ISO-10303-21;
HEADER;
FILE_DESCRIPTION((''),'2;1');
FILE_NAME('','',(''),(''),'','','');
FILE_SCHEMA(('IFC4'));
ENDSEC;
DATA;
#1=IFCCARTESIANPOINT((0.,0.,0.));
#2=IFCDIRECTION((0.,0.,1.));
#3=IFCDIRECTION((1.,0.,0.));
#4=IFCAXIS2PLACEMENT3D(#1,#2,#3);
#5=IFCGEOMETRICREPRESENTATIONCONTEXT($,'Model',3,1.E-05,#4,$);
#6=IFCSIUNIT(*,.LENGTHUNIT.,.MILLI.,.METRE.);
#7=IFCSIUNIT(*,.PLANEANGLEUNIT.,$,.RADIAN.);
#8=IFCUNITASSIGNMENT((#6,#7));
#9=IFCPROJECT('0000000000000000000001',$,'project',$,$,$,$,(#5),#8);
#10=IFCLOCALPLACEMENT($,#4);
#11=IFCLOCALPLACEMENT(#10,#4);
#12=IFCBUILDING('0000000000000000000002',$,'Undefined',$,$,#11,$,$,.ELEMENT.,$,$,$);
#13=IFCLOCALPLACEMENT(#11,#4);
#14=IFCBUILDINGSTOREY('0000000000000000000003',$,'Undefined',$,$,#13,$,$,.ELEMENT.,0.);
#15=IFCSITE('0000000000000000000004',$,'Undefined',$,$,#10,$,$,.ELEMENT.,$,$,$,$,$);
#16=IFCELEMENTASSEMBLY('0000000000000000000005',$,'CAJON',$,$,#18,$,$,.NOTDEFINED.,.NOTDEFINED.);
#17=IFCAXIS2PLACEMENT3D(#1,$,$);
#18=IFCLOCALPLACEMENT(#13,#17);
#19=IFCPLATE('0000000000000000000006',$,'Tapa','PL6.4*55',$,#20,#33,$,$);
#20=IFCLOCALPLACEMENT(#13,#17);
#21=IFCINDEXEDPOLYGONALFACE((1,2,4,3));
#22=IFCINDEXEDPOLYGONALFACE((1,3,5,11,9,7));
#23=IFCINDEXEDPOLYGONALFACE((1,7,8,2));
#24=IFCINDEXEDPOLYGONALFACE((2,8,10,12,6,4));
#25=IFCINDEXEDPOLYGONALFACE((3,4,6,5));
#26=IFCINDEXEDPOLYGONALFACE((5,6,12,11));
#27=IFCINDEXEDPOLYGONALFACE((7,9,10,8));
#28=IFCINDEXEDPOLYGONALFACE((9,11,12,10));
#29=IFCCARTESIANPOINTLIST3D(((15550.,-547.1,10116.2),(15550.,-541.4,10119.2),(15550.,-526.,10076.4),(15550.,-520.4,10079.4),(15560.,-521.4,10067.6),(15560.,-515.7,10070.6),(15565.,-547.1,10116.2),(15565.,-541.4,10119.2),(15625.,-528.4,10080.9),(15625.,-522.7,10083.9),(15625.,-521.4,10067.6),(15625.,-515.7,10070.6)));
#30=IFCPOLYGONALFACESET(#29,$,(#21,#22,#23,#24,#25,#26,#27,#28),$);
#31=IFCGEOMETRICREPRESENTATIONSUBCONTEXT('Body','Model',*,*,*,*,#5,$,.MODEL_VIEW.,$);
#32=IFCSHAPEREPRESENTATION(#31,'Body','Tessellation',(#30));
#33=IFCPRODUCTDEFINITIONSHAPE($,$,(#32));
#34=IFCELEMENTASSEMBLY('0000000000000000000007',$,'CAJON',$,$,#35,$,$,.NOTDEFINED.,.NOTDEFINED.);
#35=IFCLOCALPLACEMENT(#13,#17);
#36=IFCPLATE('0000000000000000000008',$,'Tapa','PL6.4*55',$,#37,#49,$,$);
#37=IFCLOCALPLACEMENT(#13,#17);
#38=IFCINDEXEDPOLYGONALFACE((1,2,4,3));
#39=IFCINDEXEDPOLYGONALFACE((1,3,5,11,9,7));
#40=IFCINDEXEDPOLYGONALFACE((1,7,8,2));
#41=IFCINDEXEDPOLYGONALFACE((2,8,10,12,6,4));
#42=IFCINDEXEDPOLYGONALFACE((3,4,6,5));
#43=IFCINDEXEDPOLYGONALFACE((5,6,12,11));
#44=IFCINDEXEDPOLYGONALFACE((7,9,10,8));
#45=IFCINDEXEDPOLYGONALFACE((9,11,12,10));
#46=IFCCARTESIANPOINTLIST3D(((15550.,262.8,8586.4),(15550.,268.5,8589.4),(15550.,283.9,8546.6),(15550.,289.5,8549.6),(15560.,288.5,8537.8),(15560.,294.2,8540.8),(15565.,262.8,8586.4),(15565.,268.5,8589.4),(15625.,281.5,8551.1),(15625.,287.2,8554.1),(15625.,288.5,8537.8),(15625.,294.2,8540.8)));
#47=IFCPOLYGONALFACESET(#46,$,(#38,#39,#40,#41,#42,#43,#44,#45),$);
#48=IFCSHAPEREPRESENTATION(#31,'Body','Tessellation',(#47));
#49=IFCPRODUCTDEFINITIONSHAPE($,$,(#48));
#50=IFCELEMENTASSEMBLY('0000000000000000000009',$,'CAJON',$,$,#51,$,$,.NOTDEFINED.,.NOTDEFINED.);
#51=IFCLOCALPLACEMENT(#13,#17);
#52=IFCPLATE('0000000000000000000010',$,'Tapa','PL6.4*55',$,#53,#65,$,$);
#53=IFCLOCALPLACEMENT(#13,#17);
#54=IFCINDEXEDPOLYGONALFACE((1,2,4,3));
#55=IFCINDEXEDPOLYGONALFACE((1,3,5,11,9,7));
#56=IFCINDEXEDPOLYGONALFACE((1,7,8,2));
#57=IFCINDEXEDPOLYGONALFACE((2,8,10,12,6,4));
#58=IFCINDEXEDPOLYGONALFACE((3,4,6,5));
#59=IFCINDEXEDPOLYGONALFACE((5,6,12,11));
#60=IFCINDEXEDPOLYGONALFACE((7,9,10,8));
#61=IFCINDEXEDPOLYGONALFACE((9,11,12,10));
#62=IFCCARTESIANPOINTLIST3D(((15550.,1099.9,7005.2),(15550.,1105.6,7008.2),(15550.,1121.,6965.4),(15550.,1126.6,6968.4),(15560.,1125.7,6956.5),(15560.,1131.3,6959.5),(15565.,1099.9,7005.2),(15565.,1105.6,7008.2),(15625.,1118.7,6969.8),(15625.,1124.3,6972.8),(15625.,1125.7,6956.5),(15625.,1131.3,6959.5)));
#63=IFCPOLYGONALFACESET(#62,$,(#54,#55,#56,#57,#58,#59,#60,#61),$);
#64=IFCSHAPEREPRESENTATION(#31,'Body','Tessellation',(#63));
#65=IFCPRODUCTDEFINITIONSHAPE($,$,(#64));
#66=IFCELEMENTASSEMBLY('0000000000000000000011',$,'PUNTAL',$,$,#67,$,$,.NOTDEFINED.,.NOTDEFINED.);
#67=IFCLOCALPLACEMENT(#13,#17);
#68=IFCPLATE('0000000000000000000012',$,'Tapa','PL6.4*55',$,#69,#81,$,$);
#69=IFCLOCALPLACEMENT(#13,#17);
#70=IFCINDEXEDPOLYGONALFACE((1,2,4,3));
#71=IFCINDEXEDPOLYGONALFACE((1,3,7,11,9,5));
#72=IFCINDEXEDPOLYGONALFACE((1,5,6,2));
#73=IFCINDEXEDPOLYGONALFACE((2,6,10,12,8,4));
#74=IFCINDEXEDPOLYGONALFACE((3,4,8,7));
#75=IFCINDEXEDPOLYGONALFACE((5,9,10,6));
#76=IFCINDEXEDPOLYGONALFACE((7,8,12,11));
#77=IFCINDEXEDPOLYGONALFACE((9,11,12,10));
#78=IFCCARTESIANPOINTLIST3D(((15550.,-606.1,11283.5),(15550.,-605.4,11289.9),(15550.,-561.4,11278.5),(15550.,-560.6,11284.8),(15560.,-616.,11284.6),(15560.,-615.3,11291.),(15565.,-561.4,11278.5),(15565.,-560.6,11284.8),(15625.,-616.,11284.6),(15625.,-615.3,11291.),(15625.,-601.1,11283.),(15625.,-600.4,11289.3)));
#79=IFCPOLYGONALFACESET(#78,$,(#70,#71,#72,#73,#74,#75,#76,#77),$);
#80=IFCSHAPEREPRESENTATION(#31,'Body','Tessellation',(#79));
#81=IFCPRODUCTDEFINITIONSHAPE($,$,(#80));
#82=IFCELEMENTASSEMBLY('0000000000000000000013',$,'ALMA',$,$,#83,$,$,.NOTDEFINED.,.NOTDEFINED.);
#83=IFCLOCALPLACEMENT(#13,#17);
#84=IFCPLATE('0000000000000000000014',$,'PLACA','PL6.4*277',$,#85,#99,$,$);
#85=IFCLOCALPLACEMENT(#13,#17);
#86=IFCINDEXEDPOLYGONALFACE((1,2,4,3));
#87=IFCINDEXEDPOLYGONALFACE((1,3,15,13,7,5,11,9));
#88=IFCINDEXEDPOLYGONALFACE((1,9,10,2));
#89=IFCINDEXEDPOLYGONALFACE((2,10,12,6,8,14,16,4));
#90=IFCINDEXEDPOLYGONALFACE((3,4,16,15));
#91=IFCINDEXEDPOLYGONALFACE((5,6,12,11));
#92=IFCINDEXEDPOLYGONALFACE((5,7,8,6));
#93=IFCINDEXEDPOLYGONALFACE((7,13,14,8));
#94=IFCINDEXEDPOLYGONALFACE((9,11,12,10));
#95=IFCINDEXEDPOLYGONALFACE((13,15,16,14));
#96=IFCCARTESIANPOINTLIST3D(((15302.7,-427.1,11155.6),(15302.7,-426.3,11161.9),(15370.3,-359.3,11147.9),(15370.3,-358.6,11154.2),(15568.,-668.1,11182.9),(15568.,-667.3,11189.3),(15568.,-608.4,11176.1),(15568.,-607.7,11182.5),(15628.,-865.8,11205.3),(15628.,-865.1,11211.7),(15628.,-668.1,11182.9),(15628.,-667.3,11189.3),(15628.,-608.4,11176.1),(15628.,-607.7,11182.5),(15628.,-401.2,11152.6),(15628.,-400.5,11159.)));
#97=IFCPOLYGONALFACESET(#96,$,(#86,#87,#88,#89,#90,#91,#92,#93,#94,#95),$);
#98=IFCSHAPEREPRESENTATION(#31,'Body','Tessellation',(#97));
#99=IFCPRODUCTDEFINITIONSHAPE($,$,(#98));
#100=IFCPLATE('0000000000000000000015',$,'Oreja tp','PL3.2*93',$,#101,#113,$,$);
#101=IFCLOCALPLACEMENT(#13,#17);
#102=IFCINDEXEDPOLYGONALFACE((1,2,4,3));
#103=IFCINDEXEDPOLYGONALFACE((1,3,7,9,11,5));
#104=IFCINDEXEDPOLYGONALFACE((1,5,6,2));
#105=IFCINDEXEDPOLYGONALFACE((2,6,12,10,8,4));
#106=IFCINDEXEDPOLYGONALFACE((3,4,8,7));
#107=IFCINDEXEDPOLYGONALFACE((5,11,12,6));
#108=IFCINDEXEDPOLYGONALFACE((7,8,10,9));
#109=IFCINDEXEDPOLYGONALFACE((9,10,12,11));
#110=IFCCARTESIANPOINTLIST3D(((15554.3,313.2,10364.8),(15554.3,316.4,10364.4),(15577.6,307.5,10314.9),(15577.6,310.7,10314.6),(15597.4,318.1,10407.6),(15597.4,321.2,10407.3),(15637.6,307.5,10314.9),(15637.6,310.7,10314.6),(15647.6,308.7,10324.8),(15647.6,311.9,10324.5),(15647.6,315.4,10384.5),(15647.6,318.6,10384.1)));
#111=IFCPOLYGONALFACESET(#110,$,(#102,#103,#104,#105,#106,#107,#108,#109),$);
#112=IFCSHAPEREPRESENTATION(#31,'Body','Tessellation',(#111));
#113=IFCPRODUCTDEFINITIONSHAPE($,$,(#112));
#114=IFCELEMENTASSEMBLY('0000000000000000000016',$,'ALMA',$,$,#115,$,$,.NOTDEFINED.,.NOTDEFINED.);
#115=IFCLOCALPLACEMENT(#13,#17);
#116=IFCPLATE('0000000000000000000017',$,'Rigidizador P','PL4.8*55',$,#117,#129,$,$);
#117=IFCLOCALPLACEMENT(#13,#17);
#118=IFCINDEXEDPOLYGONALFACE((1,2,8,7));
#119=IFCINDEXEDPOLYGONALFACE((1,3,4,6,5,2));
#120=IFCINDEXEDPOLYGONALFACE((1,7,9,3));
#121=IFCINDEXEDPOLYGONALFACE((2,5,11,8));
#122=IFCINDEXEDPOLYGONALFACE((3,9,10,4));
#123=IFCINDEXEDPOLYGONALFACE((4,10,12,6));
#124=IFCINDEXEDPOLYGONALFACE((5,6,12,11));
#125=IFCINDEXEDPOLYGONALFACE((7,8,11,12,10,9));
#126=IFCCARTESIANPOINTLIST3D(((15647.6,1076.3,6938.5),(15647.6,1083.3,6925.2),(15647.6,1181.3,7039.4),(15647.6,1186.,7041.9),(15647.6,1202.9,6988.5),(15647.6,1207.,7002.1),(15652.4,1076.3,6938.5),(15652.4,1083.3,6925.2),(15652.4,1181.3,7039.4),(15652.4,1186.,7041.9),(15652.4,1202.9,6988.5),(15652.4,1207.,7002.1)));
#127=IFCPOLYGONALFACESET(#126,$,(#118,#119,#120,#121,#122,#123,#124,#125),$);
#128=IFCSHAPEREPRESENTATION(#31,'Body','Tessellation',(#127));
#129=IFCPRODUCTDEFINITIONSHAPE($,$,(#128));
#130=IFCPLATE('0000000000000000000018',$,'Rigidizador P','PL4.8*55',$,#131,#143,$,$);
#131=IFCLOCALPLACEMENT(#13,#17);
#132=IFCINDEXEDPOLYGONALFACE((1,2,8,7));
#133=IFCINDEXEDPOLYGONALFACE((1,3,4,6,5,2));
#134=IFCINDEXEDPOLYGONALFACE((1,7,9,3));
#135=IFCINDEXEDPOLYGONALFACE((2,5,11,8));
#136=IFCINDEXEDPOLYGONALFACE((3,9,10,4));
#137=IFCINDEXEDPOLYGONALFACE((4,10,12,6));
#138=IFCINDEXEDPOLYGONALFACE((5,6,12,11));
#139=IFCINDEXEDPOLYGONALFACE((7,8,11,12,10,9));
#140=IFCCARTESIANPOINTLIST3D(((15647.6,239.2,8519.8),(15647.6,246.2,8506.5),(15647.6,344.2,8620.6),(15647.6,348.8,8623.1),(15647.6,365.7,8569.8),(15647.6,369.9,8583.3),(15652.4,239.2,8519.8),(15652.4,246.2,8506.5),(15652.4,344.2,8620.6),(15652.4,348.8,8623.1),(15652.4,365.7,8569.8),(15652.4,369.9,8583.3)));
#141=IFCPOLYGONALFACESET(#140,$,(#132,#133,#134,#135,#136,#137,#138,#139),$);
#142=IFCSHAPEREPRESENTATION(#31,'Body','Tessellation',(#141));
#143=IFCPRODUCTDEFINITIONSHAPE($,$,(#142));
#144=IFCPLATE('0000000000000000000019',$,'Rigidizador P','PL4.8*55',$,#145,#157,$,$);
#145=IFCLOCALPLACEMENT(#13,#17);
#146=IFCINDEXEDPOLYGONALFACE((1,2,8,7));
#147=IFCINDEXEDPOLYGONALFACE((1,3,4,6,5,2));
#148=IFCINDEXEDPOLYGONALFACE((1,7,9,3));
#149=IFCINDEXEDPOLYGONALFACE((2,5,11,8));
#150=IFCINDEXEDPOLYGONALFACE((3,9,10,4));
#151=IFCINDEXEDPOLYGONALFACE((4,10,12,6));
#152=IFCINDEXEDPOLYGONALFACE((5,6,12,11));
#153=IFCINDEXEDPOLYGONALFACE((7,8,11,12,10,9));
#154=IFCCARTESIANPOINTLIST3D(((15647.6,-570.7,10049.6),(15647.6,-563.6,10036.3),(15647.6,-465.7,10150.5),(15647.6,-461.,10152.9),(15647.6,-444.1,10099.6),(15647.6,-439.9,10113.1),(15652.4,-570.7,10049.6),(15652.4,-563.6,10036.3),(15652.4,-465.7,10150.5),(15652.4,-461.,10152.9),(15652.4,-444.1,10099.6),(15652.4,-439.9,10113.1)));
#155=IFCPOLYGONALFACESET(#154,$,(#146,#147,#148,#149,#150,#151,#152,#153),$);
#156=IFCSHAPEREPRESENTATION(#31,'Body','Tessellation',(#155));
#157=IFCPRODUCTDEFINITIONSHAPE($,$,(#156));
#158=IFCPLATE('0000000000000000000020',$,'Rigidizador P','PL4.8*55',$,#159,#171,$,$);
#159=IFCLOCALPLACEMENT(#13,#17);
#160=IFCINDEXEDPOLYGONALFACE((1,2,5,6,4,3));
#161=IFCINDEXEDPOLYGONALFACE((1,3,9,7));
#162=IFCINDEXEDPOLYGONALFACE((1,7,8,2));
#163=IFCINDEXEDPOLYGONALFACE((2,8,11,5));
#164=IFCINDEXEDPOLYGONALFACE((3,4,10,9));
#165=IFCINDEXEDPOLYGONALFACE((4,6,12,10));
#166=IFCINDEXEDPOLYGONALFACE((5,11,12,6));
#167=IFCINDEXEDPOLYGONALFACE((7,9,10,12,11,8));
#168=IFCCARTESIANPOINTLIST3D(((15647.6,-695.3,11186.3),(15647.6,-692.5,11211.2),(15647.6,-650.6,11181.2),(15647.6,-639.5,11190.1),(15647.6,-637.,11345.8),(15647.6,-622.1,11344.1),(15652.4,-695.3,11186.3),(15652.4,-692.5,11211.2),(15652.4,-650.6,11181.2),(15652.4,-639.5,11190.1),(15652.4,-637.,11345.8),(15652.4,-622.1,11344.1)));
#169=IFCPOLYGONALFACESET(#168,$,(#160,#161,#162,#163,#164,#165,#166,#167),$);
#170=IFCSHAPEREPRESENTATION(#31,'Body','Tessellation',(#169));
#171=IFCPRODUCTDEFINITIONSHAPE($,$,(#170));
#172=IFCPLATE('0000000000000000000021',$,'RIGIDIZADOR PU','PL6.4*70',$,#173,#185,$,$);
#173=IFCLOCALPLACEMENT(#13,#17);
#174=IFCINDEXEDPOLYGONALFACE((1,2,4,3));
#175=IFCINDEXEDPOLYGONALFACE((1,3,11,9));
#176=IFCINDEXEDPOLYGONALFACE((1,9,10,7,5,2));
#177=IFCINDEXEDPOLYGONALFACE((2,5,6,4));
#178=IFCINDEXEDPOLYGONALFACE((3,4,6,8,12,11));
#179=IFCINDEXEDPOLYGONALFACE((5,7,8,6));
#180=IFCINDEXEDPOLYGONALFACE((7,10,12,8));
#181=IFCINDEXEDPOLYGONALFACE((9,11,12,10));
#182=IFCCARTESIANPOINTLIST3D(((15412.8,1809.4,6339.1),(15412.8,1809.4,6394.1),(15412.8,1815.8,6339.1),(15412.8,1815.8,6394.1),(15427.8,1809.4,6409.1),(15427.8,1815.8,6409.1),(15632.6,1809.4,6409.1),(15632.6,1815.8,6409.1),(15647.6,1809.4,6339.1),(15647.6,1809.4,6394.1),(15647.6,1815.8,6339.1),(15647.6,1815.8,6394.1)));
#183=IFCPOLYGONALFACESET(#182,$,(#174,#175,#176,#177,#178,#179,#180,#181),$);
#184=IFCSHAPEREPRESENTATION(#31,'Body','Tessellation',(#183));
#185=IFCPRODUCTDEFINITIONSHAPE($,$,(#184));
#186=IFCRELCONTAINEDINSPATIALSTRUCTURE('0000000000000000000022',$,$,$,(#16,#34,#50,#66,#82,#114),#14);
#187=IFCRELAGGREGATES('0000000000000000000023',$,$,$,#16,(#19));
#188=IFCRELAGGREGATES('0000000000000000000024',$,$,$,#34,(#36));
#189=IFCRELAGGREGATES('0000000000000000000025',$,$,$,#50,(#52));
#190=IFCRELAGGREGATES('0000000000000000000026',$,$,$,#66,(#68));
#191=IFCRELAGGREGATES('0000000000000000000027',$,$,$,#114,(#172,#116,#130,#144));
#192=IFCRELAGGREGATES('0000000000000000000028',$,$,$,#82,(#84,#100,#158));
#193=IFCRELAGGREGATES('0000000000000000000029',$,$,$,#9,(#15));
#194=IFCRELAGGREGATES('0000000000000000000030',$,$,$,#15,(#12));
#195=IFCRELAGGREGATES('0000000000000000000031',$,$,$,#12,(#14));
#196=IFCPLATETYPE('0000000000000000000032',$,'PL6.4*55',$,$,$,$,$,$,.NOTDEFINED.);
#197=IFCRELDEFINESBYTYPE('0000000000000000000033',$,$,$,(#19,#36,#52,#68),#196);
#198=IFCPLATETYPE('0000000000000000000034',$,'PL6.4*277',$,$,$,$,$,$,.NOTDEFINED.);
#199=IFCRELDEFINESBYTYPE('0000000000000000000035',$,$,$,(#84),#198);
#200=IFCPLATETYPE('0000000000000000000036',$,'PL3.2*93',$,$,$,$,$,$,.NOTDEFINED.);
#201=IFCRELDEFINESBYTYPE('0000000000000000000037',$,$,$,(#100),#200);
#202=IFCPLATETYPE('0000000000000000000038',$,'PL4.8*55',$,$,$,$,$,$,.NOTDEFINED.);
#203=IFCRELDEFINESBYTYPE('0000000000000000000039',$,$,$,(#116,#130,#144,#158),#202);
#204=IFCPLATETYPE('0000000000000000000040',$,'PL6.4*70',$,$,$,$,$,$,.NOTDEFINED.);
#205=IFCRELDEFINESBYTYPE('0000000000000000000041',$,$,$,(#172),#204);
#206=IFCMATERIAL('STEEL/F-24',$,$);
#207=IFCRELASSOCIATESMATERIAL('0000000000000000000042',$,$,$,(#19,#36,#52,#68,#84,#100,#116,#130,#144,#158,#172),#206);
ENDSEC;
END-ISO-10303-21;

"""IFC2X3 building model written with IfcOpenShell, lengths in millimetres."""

from ifc_helpers import new_model, si_unit, frame, origin_with_axes, place, context, subcontext, project, spatial, polyline, outline, extrude, boolean, material, type_object, element, aggregate, save


model = new_model("IFC2X3")

# Units and contexts
model_context = context("Model", 3, precision=1e-05, world=origin_with_axes())
body_context = subcontext(model_context, "Body", "Model", "MODEL_VIEW")
ifc_project = project(units=[si_unit("LENGTHUNIT", "METRE", prefix="MILLI"), si_unit("PLANEANGLEUNIT", "RADIAN")], contexts=[model_context])

# Site, building, storey
site_placement = place(None, origin_with_axes())
site = spatial("IfcSite", under=ifc_project, at=site_placement, Name="Undefined", CompositionType="ELEMENT")
building_placement = place(site_placement, origin_with_axes())
building = spatial("IfcBuilding", under=site, at=building_placement, Name="Undefined", CompositionType="ELEMENT")
storey_placement = place(building_placement, origin_with_axes())
storey = spatial("IfcBuildingStorey", under=building, at=storey_placement, Name="Undefined", CompositionType="ELEMENT", Elevation=0.0)

# Element assemblies, plates
assembly_1_placement = place(storey_placement, origin_with_axes())
assembly_1 = element("IfcElementAssembly", 1, at=assembly_1_placement, inside=storey, Name="CAJON", AssemblyPlace="NOTDEFINED", PredefinedType="NOTDEFINED")
ifc_material_1 = material(Name="STEEL/F-24")
plate_type_1 = type_object("IfcPlateType", Name="PL6.4*55", PredefinedType="NOTDEFINED")
plate_1_placement = place(assembly_1_placement, frame((15625.0, -518.5, 10069.1), z_axis=(0.0, 0.883788, 0.467888), x_axis=(-1.0, 0.0, 0.0)))
plate_1 = element("IfcPlate", 2, at=plate_1_placement, type_object=plate_type_1, material=ifc_material_1, Name="Tapa", Description="PL6.4*55", context=body_context, shape_type="SweptSolid", body=[
    extrude(outline(polyline([(0.0, 0.0), (65.0, 0.0), (75.0, 10.0), (75.0, 55.0), (60.0, 55.0), (0.0, 15.0), (0.0, 0.0)])), frame((0.0, 0.0, -3.2), z_axis=(0.0, 0.0, 1.0), x_axis=(1.0, 0.0, 0.0)), (0.0, 0.0, 1.0), 6.4),
])
aggregate(assembly_1, [plate_1])
assembly_2_placement = place(storey_placement, origin_with_axes())
assembly_2 = element("IfcElementAssembly", 3, at=assembly_2_placement, inside=storey, Name="CAJON", AssemblyPlace="NOTDEFINED", PredefinedType="NOTDEFINED")
plate_2_placement = place(assembly_2_placement, frame((15625.0, 291.4, 8539.3), z_axis=(0.0, 0.883788, 0.467888), x_axis=(-1.0, 0.0, 0.0)))
plate_2 = element("IfcPlate", 4, at=plate_2_placement, type_object=plate_type_1, material=ifc_material_1, Name="Tapa", Description="PL6.4*55", context=body_context, shape_type="SweptSolid", body=[
    extrude(outline(polyline([(0.0, 0.0), (65.0, 0.0), (75.0, 10.0), (75.0, 55.0), (60.0, 55.0), (0.0, 15.0), (0.0, 0.0)])), frame((0.0, 0.0, -3.2), z_axis=(0.0, 0.0, 1.0), x_axis=(1.0, 0.0, 0.0)), (0.0, 0.0, 1.0), 6.4),
])
aggregate(assembly_2, [plate_2])
assembly_3_placement = place(storey_placement, origin_with_axes())
assembly_3 = element("IfcElementAssembly", 5, at=assembly_3_placement, inside=storey, Name="CAJON", AssemblyPlace="NOTDEFINED", PredefinedType="NOTDEFINED")
plate_3_placement = place(assembly_3_placement, frame((15625.0, 1128.5, 6958.0), z_axis=(0.0, 0.883788, 0.467888), x_axis=(-1.0, 0.0, 0.0)))
plate_3 = element("IfcPlate", 6, at=plate_3_placement, type_object=plate_type_1, material=ifc_material_1, Name="Tapa", Description="PL6.4*55", context=body_context, shape_type="SweptSolid", body=[
    extrude(outline(polyline([(0.0, 0.0), (65.0, 0.0), (75.0, 10.0), (75.0, 55.0), (60.0, 55.0), (0.0, 15.0), (0.0, 0.0)])), frame((0.0, 0.0, -3.2), z_axis=(0.0, 0.0, 1.0), x_axis=(1.0, 0.0, 0.0)), (0.0, 0.0, 1.0), 6.4),
])
aggregate(assembly_3, [plate_3])
assembly_4_placement = place(storey_placement, origin_with_axes())
assembly_4 = element("IfcElementAssembly", 7, at=assembly_4_placement, inside=storey, Name="PUNTAL", AssemblyPlace="NOTDEFINED", PredefinedType="NOTDEFINED")
plate_4_placement = place(assembly_4_placement, frame((15625.0, -615.7, 11287.8), z_axis=(0.0, -0.112644, -0.993635), x_axis=(-1.0, 0.0, 0.0)))
plate_4 = element("IfcPlate", 8, at=plate_4_placement, type_object=plate_type_1, material=ifc_material_1, Name="Tapa", Description="PL6.4*55", context=body_context, shape_type="SweptSolid", body=[
    extrude(outline(polyline([(0.0, 0.0), (65.0, 0.0), (75.0, 10.0), (75.0, 55.0), (60.0, 55.0), (0.0, 15.0), (0.0, 0.0)])), frame((0.0, 0.0, -3.2), z_axis=(0.0, 0.0, 1.0), x_axis=(1.0, 0.0, 0.0)), (0.0, 0.0, 1.0), 6.4),
])
aggregate(assembly_4, [plate_4])

# Element assemblies, plates
assembly_5_placement = place(storey_placement, origin_with_axes())
assembly_5 = element("IfcElementAssembly", 9, at=assembly_5_placement, inside=storey, Name="ALMA", AssemblyPlace="NOTDEFINED", PredefinedType="NOTDEFINED")
plate_type_2 = type_object("IfcPlateType", Name="PL6.4*277", PredefinedType="NOTDEFINED")
plate_5_placement = place(assembly_5_placement, frame((15628.0, -400.9, 11155.8), z_axis=(-0.000019, -0.112723, -0.993626), x_axis=(0.0, -0.993626, 0.112723)))
plate_5 = element("IfcPlate", 10, at=plate_5_placement, type_object=plate_type_2, material=ifc_material_1, Name="PLACA", Description="PL6.4*277", context=body_context, shape_type="CSG", body=[
    boolean("DIFFERENCE", extrude(outline(polyline([(0.0, 0.0), (467.5, 0.0), (26.0, 325.3), (-42.2, 257.7), (0.0, 0.0)])), frame((0.0, 0.0, -3.2), z_axis=(0.0, 0.0, 1.0), x_axis=(1.0, 0.0, 0.0)), (0.0, 0.0, 1.0), 6.4), extrude(outline(polyline([(0.0, 0.0), (60.0, 0.0), (60.0, 60.0), (0.0, 60.0), (0.0, 0.0)])), frame((208.6, 0.0, 7.4), z_axis=(0.000328, 0.000019, -1.0), x_axis=(0.0, 1.0, 0.000019)), (0.0, 0.0, 1.0), 12.0)),
])
plate_type_3 = type_object("IfcPlateType", Name="PL3.2*93", PredefinedType="NOTDEFINED")
plate_6_placement = place(assembly_5_placement, frame((15577.6, 309.1, 10314.7), z_axis=(0.0, -0.993635, 0.112644), x_axis=(1.0, -0.000004, -0.000037)))
plate_6 = element("IfcPlate", 11, at=plate_6_placement, type_object=plate_type_3, material=ifc_material_1, Name="Oreja tp", Description="PL3.2*93", context=body_context, shape_type="SweptSolid", body=[
    extrude(outline(polyline([(0.0, 0.0), (60.0, 0.0), (70.0, 10.0), (70.0, 70.0), (19.8, 93.3), (-23.3, 50.2), (0.0, 0.0)])), frame((0.0, 0.0, -1.6), z_axis=(0.0, 0.0, 1.0), x_axis=(1.0, 0.0, 0.0)), (0.0, 0.0, 1.0), 3.2),
])
assembly_6_placement = place(storey_placement, origin_with_axes())
assembly_6 = element("IfcElementAssembly", 12, at=assembly_6_placement, inside=storey, Name="ALMA", AssemblyPlace="NOTDEFINED", PredefinedType="NOTDEFINED")
plate_type_4 = type_object("IfcPlateType", Name="PL4.8*55", PredefinedType="NOTDEFINED")
plate_7_placement = place(assembly_6_placement, frame((15650.0, 1083.3, 6925.2), z_axis=(-1.0, 0.0, 0.0), x_axis=(0.0, -0.467875, 0.883795)))
plate_7 = element("IfcPlate", 13, at=plate_7_placement, type_object=plate_type_4, material=ifc_material_1, Name="Rigidizador P", Description="PL4.8*55", context=body_context, shape_type="SweptSolid", body=[
    extrude(outline(polyline([(0.0, 0.0), (15.0, 0.0), (55.0, 140.0), (55.0, 145.3), (10.0, 145.3), (0.0, 135.3), (0.0, 0.0)])), frame((0.0, 0.0, -2.4), z_axis=(0.0, 0.0, 1.0), x_axis=(1.0, 0.0, 0.0)), (0.0, 0.0, 1.0), 4.8),
])
plate_8_placement = place(assembly_6_placement, frame((15650.0, 246.2, 8506.5), z_axis=(-1.0, 0.0, 0.0), x_axis=(0.0, -0.467875, 0.883795)))
plate_8 = element("IfcPlate", 14, at=plate_8_placement, type_object=plate_type_4, material=ifc_material_1, Name="Rigidizador P", Description="PL4.8*55", context=body_context, shape_type="SweptSolid", body=[
    extrude(outline(polyline([(0.0, 0.0), (15.0, 0.0), (55.0, 140.0), (55.0, 145.3), (10.0, 145.3), (0.0, 135.3), (0.0, 0.0)])), frame((0.0, 0.0, -2.4), z_axis=(0.0, 0.0, 1.0), x_axis=(1.0, 0.0, 0.0)), (0.0, 0.0, 1.0), 4.8),
])
plate_9_placement = place(assembly_6_placement, frame((15650.0, -563.6, 10036.3), z_axis=(-1.0, 0.0, 0.0), x_axis=(0.0, -0.467875, 0.883795)))
plate_9 = element("IfcPlate", 15, at=plate_9_placement, type_object=plate_type_4, material=ifc_material_1, Name="Rigidizador P", Description="PL4.8*55", context=body_context, shape_type="SweptSolid", body=[
    extrude(outline(polyline([(0.0, 0.0), (15.0, 0.0), (55.0, 140.0), (55.0, 145.3), (10.0, 145.3), (0.0, 135.3), (0.0, 0.0)])), frame((0.0, 0.0, -2.4), z_axis=(0.0, 0.0, 1.0), x_axis=(1.0, 0.0, 0.0)), (0.0, 0.0, 1.0), 4.8),
])

# Plates
plate_10_placement = place(assembly_5_placement, frame((15650.0, -622.1, 11344.1), z_axis=(1.0, 0.0, 0.0), x_axis=(0.0, -0.993635, 0.112644)))
plate_10 = element("IfcPlate", 16, at=plate_10_placement, type_object=plate_type_4, material=ifc_material_1, Name="Rigidizador P", Description="PL4.8*55", context=body_context, shape_type="SweptSolid", body=[
    extrude(outline(polyline([(0.0, 0.0), (15.0, 0.0), (55.0, 140.0), (55.0, 165.0), (10.0, 165.0), (0.0, 155.0), (0.0, 0.0)])), frame((0.0, 0.0, -2.4), z_axis=(0.0, 0.0, 1.0), x_axis=(1.0, 0.0, 0.0)), (0.0, 0.0, 1.0), 4.8),
])
plate_type_5 = type_object("IfcPlateType", Name="PL6.4*70", PredefinedType="NOTDEFINED")
plate_11_placement = place(assembly_6_placement, frame((15647.6, 1812.6, 6409.1), z_axis=(-0.000003, -1.0, 0.0), x_axis=(-1.0, 0.000003, 0.0)))
plate_11 = element("IfcPlate", 17, at=plate_11_placement, type_object=plate_type_5, material=ifc_material_1, Name="RIGIDIZADOR PU", Description="PL6.4*70", context=body_context, shape_type="SweptSolid", body=[
    extrude(outline(polyline([(0.0, 15.0), (15.0, 0.0), (219.8, 0.0), (234.8, 15.0), (234.8, 70.0), (0.0, 70.0), (0.0, 15.0)])), frame((0.0, 0.0, -3.2), z_axis=(0.0, 0.0, 1.0), x_axis=(1.0, 0.0, 0.0)), (0.0, 0.0, 1.0), 6.4),
])

aggregate(assembly_6, [plate_11, plate_7, plate_8, plate_9])
aggregate(assembly_5, [plate_5, plate_6, plate_10])

save(model, "model.ifc")
